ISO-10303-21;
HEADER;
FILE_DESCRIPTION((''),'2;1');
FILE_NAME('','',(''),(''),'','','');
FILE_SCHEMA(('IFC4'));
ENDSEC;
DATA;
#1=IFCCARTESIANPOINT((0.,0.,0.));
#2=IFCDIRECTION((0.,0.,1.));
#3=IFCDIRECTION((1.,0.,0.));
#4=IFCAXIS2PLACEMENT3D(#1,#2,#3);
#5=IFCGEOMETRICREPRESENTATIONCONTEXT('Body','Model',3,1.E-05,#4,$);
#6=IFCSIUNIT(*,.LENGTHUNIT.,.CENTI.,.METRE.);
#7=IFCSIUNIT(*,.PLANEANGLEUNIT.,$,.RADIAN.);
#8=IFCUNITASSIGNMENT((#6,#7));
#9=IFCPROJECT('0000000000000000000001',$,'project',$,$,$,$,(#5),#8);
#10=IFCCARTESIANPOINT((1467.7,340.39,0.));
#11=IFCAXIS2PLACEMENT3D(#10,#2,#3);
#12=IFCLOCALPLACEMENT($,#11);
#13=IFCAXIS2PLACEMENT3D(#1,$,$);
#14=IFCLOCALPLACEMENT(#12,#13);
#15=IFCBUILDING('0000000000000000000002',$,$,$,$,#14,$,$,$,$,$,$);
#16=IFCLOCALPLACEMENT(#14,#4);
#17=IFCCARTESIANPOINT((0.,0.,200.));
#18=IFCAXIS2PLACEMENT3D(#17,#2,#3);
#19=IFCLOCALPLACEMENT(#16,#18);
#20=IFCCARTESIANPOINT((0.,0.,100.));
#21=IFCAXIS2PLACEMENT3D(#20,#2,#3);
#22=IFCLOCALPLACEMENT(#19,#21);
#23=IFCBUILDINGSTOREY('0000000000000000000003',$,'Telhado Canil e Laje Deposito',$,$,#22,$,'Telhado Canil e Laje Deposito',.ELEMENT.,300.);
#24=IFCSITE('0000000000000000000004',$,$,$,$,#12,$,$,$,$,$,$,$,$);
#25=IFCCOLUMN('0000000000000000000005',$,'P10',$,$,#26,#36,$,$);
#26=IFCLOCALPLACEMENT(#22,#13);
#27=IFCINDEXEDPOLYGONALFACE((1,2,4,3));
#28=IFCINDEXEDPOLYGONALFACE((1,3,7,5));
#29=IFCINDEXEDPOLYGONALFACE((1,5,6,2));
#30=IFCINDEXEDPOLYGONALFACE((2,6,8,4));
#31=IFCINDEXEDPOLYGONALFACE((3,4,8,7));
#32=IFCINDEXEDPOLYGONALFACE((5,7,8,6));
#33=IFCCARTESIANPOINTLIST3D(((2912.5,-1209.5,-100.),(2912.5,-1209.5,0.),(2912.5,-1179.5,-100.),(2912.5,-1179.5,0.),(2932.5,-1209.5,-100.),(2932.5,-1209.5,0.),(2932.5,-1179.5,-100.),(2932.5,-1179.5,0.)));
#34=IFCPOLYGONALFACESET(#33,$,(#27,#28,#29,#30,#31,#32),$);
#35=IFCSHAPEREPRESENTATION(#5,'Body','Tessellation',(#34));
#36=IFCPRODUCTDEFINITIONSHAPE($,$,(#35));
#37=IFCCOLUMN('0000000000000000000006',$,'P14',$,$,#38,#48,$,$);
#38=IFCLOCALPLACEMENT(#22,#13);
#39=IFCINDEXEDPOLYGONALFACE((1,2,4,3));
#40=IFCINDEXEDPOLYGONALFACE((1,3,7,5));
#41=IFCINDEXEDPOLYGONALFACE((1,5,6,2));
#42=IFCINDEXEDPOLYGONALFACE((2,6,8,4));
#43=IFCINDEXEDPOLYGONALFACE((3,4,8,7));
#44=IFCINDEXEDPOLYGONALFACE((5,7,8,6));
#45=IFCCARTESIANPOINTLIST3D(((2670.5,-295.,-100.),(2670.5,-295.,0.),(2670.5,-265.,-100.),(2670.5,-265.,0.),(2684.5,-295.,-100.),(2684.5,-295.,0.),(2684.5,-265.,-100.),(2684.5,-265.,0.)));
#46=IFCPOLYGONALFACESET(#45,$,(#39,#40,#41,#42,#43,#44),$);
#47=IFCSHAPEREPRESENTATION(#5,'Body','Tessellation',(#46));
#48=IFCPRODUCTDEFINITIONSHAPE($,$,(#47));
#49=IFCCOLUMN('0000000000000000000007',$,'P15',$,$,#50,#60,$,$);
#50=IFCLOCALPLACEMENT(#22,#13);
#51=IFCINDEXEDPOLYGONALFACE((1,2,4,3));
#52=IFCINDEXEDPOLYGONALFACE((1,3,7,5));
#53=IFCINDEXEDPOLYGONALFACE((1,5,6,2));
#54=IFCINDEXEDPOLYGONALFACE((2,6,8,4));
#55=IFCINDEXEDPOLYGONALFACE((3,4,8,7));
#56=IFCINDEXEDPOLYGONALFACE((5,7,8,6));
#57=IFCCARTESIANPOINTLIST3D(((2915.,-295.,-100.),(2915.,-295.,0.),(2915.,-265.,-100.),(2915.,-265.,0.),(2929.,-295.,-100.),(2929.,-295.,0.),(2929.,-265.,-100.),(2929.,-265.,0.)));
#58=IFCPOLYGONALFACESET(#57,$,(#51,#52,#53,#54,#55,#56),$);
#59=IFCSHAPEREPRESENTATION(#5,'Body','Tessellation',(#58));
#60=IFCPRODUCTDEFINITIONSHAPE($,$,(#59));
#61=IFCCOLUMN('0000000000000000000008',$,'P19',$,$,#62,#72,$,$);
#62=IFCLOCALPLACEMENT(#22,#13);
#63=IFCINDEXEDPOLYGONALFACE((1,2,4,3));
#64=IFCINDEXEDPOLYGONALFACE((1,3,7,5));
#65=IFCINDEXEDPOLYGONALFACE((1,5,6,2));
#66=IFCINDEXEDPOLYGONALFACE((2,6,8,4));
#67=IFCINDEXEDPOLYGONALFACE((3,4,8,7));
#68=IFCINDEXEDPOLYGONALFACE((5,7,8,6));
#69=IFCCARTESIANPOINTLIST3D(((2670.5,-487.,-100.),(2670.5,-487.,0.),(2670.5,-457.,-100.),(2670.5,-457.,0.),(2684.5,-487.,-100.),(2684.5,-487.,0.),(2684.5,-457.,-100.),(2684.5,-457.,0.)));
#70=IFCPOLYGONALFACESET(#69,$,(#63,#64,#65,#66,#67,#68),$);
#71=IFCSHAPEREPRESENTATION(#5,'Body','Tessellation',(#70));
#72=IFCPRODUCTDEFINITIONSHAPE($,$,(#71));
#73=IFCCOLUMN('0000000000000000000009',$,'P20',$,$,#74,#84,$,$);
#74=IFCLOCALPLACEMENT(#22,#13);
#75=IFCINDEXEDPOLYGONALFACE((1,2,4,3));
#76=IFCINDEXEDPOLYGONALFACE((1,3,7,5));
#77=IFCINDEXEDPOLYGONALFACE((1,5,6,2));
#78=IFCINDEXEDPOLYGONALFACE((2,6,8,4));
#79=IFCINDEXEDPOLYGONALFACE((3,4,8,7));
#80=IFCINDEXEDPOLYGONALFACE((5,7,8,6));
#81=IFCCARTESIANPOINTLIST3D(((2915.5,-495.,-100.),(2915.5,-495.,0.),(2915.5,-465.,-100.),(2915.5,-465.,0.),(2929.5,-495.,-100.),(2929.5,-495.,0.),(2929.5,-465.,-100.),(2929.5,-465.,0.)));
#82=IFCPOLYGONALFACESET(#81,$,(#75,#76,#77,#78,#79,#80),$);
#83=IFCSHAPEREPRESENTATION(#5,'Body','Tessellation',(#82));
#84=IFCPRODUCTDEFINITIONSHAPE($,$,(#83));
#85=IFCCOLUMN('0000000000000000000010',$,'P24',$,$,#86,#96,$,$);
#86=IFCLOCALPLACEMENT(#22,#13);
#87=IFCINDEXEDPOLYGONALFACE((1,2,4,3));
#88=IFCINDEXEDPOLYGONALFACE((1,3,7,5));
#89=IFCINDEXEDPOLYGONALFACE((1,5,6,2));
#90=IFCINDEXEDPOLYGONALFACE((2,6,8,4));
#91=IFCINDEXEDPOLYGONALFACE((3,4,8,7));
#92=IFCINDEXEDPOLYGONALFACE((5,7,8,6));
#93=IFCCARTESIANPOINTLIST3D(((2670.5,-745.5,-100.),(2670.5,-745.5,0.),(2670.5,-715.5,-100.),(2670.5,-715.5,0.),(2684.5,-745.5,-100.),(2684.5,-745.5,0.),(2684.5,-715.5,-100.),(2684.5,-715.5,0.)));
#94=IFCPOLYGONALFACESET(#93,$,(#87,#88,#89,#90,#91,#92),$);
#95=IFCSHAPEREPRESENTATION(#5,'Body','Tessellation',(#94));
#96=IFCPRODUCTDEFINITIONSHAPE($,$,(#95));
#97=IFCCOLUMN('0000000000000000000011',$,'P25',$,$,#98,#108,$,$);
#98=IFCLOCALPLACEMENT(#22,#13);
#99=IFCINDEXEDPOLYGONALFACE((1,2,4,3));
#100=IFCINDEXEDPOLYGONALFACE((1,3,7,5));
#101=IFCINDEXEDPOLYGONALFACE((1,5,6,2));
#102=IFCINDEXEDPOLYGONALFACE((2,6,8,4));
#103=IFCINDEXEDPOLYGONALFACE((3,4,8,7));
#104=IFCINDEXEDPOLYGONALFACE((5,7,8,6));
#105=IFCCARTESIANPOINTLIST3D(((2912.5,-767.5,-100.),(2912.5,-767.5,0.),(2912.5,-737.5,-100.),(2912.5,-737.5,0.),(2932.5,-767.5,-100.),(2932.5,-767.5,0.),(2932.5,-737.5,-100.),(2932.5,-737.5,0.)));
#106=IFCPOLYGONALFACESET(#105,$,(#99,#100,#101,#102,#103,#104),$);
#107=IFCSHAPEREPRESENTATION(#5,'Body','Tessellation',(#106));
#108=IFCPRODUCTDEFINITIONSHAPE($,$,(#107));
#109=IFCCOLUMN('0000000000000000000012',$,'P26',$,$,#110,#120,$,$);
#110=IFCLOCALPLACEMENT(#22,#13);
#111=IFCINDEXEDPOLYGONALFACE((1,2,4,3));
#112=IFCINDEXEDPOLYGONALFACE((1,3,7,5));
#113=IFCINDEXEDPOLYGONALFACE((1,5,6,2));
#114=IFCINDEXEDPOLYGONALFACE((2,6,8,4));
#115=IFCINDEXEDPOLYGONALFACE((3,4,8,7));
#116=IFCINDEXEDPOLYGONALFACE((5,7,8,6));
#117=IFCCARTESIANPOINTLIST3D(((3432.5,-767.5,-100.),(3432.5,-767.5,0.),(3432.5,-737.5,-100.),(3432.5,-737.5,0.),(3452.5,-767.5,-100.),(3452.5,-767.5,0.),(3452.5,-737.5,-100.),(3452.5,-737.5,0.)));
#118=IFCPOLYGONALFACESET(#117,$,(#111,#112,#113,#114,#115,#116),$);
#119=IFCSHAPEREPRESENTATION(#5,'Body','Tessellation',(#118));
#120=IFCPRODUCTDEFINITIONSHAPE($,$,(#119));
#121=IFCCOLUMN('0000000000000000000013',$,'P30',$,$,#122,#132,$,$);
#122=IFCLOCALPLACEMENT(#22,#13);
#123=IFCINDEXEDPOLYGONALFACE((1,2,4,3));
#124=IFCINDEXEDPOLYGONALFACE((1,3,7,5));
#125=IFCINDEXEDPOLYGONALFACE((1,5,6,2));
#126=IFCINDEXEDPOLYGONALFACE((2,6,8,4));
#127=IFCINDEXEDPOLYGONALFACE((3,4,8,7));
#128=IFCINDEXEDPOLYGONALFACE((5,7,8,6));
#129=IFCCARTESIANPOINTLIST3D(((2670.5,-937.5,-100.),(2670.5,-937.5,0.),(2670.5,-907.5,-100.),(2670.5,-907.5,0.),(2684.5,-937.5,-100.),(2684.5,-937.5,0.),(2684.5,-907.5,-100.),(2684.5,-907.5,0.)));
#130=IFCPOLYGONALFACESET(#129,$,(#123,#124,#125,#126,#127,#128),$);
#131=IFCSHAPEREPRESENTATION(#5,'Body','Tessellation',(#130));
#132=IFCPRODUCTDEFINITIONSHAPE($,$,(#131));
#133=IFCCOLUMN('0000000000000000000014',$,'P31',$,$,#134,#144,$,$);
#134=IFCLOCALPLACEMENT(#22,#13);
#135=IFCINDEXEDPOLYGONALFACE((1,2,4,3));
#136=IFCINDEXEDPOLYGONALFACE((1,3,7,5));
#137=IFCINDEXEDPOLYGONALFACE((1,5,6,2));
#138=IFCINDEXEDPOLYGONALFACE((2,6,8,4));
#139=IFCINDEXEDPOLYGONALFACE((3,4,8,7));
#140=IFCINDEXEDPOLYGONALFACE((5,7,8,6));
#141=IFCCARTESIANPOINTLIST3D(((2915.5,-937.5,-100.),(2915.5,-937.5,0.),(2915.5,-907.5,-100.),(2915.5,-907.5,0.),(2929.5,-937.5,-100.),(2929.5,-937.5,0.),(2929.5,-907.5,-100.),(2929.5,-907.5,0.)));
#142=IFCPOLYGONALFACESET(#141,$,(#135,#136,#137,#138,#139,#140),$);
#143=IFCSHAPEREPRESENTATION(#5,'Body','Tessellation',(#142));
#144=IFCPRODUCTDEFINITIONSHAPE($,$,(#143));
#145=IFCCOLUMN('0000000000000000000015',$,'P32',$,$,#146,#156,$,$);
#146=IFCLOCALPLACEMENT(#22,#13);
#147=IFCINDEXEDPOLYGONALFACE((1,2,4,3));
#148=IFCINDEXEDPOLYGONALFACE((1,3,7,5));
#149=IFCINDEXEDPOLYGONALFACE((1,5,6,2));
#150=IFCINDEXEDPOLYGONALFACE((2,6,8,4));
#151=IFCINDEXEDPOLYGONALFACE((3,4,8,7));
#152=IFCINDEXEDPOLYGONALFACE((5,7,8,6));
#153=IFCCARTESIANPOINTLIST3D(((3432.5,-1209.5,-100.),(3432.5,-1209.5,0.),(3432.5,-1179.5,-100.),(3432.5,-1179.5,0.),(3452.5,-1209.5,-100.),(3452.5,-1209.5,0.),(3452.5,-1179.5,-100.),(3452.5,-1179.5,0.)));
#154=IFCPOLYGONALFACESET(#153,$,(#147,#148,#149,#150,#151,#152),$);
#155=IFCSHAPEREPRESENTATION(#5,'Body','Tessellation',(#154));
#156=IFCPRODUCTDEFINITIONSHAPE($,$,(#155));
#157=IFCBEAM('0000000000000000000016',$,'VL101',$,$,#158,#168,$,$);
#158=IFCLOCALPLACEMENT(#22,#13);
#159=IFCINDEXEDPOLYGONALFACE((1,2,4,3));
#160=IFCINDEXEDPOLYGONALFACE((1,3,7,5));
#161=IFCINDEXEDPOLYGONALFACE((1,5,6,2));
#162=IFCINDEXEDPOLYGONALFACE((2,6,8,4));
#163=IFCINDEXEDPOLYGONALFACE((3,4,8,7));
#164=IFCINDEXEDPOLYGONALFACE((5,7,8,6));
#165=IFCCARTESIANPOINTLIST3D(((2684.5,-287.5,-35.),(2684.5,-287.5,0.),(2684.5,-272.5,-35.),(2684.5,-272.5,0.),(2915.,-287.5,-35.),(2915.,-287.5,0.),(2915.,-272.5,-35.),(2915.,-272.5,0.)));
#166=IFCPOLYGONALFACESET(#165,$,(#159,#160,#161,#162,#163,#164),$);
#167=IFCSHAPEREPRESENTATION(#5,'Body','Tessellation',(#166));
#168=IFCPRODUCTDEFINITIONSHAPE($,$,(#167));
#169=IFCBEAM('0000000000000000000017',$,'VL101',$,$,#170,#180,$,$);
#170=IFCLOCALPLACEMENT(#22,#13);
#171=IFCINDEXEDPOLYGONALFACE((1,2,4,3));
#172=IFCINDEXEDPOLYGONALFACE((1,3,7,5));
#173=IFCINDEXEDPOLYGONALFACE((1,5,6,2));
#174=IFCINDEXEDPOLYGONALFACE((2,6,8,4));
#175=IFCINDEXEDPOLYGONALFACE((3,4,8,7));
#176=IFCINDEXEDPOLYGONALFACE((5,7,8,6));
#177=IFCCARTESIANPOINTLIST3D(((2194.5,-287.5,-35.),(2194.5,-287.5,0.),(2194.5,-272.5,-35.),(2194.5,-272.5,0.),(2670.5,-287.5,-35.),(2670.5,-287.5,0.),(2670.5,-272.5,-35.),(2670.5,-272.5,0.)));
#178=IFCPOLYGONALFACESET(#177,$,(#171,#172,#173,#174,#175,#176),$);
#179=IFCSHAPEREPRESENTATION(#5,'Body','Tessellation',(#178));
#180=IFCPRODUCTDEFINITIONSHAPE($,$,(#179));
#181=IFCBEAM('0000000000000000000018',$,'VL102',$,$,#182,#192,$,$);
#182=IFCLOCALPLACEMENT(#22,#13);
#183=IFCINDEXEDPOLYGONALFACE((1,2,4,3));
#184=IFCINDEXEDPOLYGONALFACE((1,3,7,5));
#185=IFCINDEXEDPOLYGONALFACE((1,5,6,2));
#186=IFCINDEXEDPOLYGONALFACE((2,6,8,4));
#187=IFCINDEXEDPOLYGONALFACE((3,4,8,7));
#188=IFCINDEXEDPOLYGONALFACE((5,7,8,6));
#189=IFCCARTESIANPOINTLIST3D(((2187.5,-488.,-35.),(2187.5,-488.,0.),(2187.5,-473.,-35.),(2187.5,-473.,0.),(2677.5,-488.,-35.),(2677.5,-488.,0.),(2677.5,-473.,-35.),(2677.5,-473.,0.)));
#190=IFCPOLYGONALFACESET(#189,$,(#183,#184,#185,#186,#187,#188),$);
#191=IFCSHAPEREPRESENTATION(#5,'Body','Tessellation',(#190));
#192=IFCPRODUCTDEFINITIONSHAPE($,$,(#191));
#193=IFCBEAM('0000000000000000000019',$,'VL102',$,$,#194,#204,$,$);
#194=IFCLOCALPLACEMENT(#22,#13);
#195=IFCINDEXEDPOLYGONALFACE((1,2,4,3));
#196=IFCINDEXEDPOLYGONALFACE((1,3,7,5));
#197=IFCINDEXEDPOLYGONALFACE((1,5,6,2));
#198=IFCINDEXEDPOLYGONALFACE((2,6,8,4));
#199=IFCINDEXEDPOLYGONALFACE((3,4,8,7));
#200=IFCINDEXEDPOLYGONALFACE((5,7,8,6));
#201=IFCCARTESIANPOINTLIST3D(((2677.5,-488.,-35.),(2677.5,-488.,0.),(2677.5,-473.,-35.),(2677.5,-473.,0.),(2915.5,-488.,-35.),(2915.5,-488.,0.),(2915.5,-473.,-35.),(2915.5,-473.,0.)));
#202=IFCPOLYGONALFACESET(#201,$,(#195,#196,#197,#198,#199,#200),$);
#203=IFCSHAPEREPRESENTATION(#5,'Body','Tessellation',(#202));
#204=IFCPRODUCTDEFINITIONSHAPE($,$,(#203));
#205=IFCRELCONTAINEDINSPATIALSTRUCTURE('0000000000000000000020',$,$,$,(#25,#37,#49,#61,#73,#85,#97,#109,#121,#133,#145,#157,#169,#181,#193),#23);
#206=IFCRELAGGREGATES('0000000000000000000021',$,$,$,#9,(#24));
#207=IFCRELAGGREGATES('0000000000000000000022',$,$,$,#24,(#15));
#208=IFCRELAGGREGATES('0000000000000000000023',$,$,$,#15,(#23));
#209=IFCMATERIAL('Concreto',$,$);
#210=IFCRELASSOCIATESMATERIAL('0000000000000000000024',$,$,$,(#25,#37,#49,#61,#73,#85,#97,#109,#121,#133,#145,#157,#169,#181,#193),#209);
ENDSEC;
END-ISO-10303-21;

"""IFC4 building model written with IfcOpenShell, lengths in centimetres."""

from ifc_helpers import new_model, si_unit, frame, origin, origin_with_axes, origin_2d_with_axis, place, context, project, spatial, rectangle, extrude, material, element, save


model = new_model("IFC4")

# Units and contexts
model_context = context("Model", 3, precision=1e-05, world=origin_with_axes(), identifier="Body")
ifc_project = project(units=[si_unit("LENGTHUNIT", "METRE", prefix="CENTI"), si_unit("PLANEANGLEUNIT", "RADIAN")], contexts=[model_context])

# Site, building, storey
site_placement = place(None, frame((1467.7, 340.39, 0.0), z_axis=(0.0, 0.0, 1.0), x_axis=(1.0, 0.0, 0.0)))
site = spatial("IfcSite", under=ifc_project, at=site_placement)
building_placement = place(site_placement, origin())
building = spatial("IfcBuilding", under=site, at=building_placement)
placement_1 = place(building_placement, origin_with_axes())
placement_2 = place(placement_1, frame((0.0, 0.0, 200.0), z_axis=(0.0, 0.0, 1.0), x_axis=(1.0, 0.0, 0.0)))
storey_placement = place(placement_2, frame((0.0, 0.0, 100.0), z_axis=(0.0, 0.0, 1.0), x_axis=(1.0, 0.0, 0.0)))
storey = spatial("IfcBuildingStorey", under=building, at=storey_placement, Name="Telhado Canil e Laje Deposito", LongName="Telhado Canil e Laje Deposito", CompositionType="ELEMENT", Elevation=300.0)

# Columns
ifc_material = material(Name="Concreto")
column_1_placement = place(storey_placement, frame((2922.5, -1194.5, 0.0), z_axis=(0.0, 0.0, 1.0), x_axis=(1.0, 0.0, 0.0)))
element("IfcColumn", 1, at=column_1_placement, inside=storey, material=ifc_material, Name="P10", context=model_context, shape_type="SolidModel", body=[
    extrude(rectangle(XDim=20.0, YDim=30.0, at=origin_2d_with_axis()), origin_with_axes(), (0.0, 0.0, -1.0), 100.0),
])
for number, where, z_axis, x_axis, name in (
    (2, (2677.5, -280.0, 0.0), (0.0, 0.0, 1.0), (1.0, 0.0, 0.0), "P14"),
    (3, (2922.0, -280.0, 0.0), (0.0, 0.0, 1.0), (1.0, 0.0, 0.0), "P15"),
):
    element("IfcColumn", number, at=place(storey_placement, frame(where, z_axis=z_axis, x_axis=x_axis)), inside=storey, material=ifc_material, Name=name, context=model_context, shape_type="SolidModel", body=[
        extrude(rectangle(XDim=14.0, YDim=30.0, at=origin_2d_with_axis()), origin_with_axes(), (0.0, 0.0, -1.0), 100.0),
    ])
column_2_placement = place(storey_placement, frame((2677.5, -472.0, 0.0), z_axis=(0.0, 0.0, 1.0), x_axis=(1.0, 0.0, 0.0)))
element("IfcColumn", 4, at=column_2_placement, inside=storey, material=ifc_material, Name="P19", context=model_context, shape_type="SolidModel", body=[
    extrude(rectangle(XDim=14.0, YDim=30.0, at=origin_2d_with_axis()), frame((0.0, 0.0, 0.0), z_axis=(0.0, 0.0, 1.0), x_axis=(-1.0, 0.0, 0.0)), (0.0, 0.0, -1.0), 100.0),
])
for number, where, z_axis, x_axis, name in (
    (5, (2922.5, -480.0, 0.0), (0.0, 0.0, 1.0), (1.0, 0.0, 0.0), "P20"),
    (6, (2677.5, -730.5, 0.0), (0.0, 0.0, 1.0), (1.0, 0.0, 0.0), "P24"),
):
    element("IfcColumn", number, at=place(storey_placement, frame(where, z_axis=z_axis, x_axis=x_axis)), inside=storey, material=ifc_material, Name=name, context=model_context, shape_type="SolidModel", body=[
        extrude(rectangle(XDim=14.0, YDim=30.0, at=origin_2d_with_axis()), origin_with_axes(), (0.0, 0.0, -1.0), 100.0),
    ])
column_3_placement = place(storey_placement, frame((2922.5, -752.5, 0.0), z_axis=(0.0, 0.0, 1.0), x_axis=(1.0, 0.0, 0.0)))
element("IfcColumn", 7, at=column_3_placement, inside=storey, material=ifc_material, Name="P25", context=model_context, shape_type="SolidModel", body=[
    extrude(rectangle(XDim=20.0, YDim=30.0, at=origin_2d_with_axis()), frame((0.0, 0.0, 0.0), z_axis=(0.0, 0.0, 1.0), x_axis=(-1.0, 0.0, 0.0)), (0.0, 0.0, -1.0), 100.0),
])
column_4_placement = place(storey_placement, frame((3442.5, -752.5, 0.0), z_axis=(0.0, 0.0, 1.0), x_axis=(1.0, 0.0, 0.0)))
element("IfcColumn", 8, at=column_4_placement, inside=storey, material=ifc_material, Name="P26", context=model_context, shape_type="SolidModel", body=[
    extrude(rectangle(XDim=20.0, YDim=30.0, at=origin_2d_with_axis()), origin_with_axes(), (0.0, 0.0, -1.0), 100.0),
])
for number, where, z_axis, x_axis, name in (
    (9, (2677.5, -922.5, 0.0), (0.0, 0.0, 1.0), (1.0, 0.0, 0.0), "P30"),
    (10, (2922.5, -922.5, 0.0), (0.0, 0.0, 1.0), (1.0, 0.0, 0.0), "P31"),
):
    element("IfcColumn", number, at=place(storey_placement, frame(where, z_axis=z_axis, x_axis=x_axis)), inside=storey, material=ifc_material, Name=name, context=model_context, shape_type="SolidModel", body=[
        extrude(rectangle(XDim=14.0, YDim=30.0, at=origin_2d_with_axis()), origin_with_axes(), (0.0, 0.0, -1.0), 100.0),
    ])
column_5_placement = place(storey_placement, frame((3442.5, -1194.5, 0.0), z_axis=(0.0, 0.0, 1.0), x_axis=(1.0, 0.0, 0.0)))
element("IfcColumn", 11, at=column_5_placement, inside=storey, material=ifc_material, Name="P32", context=model_context, shape_type="SolidModel", body=[
    extrude(rectangle(XDim=20.0, YDim=30.0, at=origin_2d_with_axis()), origin_with_axes(), (0.0, 0.0, -1.0), 100.0),
])

# Beams
beam_1_placement = place(storey_placement, frame((2799.75, -280.0, 0.0), z_axis=(0.0, 0.0, 1.0), x_axis=(1.0, 0.0, 0.0)))
element("IfcBeam", 12, at=beam_1_placement, inside=storey, material=ifc_material, Name="VL101", context=model_context, shape_type="SolidModel", body=[
    extrude(rectangle(XDim=15.0, YDim=35.0, at=origin_2d_with_axis()), frame((-115.25, 0.0, -17.5), z_axis=(1.0, 0.0, 0.0), x_axis=(0.0, 1.0, 0.0)), (0.0, 0.0, 1.0), 230.5),
])
beam_2_placement = place(storey_placement, frame((2432.5, -280.0, 0.0), z_axis=(0.0, 0.0, 1.0), x_axis=(1.0, 0.0, 0.0)))
element("IfcBeam", 13, at=beam_2_placement, inside=storey, material=ifc_material, Name="VL101", context=model_context, shape_type="SolidModel", body=[
    extrude(rectangle(XDim=15.0, YDim=35.0, at=origin_2d_with_axis()), frame((-238.0, 0.0, -17.5), z_axis=(1.0, 0.0, 0.0), x_axis=(0.0, 1.0, 0.0)), (0.0, 0.0, 1.0), 476.0),
])
beam_3_placement = place(storey_placement, frame((2432.5, -480.5, 0.0), z_axis=(0.0, 0.0, 1.0), x_axis=(1.0, 0.0, 0.0)))
element("IfcBeam", 14, at=beam_3_placement, inside=storey, material=ifc_material, Name="VL102", context=model_context, shape_type="SolidModel", body=[
    extrude(rectangle(XDim=15.0, YDim=35.0, at=origin_2d_with_axis()), frame((-245.0, 0.0, -17.5), z_axis=(1.0, 0.0, 0.0), x_axis=(0.0, 1.0, 0.0)), (0.0, 0.0, 1.0), 490.0),
])
beam_4_placement = place(storey_placement, frame((2796.5, -480.5, 0.0), z_axis=(0.0, 0.0, 1.0), x_axis=(1.0, 0.0, 0.0)))
element("IfcBeam", 15, at=beam_4_placement, inside=storey, material=ifc_material, Name="VL102", context=model_context, shape_type="SolidModel", body=[
    extrude(rectangle(XDim=15.0, YDim=35.0, at=origin_2d_with_axis()), frame((-119.0, 0.0, -17.5), z_axis=(1.0, 0.0, 0.0), x_axis=(0.0, 1.0, 0.0)), (0.0, 0.0, 1.0), 238.0),
])

save(model, "model.ifc")
